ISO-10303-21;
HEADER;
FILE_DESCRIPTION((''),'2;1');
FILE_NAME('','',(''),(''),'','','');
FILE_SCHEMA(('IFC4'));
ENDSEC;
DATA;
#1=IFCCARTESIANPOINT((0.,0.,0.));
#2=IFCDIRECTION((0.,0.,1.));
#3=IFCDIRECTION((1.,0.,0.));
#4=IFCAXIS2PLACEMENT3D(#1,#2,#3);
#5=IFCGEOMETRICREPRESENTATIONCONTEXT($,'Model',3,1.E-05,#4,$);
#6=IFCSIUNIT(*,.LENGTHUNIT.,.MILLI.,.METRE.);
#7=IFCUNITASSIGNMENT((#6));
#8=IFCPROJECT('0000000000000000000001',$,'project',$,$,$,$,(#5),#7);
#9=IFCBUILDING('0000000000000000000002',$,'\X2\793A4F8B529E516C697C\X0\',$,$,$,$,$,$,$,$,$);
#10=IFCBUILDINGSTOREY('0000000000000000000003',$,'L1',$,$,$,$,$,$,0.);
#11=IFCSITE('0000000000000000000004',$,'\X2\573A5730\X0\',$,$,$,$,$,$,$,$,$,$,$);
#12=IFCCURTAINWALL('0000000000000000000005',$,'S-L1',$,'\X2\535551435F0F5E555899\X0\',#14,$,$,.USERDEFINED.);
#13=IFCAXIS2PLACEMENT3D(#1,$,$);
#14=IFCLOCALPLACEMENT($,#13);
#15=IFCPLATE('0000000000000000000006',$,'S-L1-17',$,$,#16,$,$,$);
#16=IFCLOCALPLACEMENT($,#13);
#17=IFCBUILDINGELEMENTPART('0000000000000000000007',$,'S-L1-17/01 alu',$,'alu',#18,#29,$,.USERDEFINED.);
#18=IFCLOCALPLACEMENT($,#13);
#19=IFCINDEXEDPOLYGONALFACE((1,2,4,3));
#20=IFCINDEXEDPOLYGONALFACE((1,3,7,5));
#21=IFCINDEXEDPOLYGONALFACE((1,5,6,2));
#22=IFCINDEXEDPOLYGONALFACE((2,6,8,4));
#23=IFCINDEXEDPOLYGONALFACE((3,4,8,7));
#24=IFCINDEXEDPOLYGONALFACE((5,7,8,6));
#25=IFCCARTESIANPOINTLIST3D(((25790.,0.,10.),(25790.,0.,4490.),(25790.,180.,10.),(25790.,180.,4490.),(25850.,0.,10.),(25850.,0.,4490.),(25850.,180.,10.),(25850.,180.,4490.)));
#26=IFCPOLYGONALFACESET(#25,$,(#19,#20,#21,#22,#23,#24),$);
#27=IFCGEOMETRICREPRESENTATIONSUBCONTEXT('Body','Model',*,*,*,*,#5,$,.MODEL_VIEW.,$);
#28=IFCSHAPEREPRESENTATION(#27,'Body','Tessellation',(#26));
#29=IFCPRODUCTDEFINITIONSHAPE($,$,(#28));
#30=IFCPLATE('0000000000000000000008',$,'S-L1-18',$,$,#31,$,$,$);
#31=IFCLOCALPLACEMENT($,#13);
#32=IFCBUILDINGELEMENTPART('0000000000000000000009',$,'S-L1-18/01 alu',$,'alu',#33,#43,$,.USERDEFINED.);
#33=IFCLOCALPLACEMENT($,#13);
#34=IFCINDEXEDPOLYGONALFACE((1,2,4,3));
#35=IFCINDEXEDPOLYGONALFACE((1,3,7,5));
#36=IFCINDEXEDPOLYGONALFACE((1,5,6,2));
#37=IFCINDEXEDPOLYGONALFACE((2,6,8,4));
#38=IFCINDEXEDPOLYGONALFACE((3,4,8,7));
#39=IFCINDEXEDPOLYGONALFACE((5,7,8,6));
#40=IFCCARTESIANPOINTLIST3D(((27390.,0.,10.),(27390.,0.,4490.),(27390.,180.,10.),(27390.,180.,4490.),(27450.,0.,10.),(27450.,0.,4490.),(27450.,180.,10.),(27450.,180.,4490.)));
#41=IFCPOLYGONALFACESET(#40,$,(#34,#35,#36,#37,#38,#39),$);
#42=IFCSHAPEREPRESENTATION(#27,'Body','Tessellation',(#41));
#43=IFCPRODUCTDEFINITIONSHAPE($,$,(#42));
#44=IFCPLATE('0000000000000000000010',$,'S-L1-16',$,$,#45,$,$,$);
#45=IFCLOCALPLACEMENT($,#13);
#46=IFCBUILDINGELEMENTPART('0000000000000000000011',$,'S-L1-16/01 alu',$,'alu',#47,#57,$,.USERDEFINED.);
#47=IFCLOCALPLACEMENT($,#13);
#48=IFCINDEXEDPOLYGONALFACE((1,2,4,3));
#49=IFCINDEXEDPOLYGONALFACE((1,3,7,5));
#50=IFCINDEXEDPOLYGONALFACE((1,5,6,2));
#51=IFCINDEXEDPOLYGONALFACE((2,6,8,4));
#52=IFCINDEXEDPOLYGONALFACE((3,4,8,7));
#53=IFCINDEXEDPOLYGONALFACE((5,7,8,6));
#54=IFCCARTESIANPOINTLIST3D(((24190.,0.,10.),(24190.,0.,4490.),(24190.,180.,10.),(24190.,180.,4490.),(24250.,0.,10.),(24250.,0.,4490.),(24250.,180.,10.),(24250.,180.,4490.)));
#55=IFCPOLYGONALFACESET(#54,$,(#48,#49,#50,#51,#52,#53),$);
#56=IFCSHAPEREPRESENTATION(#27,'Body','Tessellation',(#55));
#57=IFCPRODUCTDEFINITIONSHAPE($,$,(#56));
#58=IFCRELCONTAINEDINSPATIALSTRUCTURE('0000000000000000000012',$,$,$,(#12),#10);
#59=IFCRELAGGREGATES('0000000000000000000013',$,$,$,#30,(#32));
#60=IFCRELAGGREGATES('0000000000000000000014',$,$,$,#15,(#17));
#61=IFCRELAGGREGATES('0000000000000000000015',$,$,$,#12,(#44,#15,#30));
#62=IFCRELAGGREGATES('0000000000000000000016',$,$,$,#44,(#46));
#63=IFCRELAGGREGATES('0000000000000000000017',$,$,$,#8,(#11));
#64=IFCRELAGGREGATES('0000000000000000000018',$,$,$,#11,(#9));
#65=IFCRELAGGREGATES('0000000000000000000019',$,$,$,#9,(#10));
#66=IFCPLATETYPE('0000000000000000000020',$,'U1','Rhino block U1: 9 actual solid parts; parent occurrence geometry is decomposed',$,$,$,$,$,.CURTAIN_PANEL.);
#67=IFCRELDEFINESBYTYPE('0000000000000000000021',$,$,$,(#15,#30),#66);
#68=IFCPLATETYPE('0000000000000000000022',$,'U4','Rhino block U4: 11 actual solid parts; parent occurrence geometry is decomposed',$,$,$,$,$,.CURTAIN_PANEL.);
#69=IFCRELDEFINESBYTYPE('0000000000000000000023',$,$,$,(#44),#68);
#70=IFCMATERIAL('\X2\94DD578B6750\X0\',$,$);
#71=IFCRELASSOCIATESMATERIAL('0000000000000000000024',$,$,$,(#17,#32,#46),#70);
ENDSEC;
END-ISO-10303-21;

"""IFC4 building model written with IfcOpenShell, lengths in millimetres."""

from ifc_helpers import new_model, si_unit, frame, frame_2d, origin, origin_with_axes, place, context, subcontext, project, spatial, rectangle, extrude, source, transform, mapped, material, type_object, element, aggregate, save


model = new_model("IFC4")

# Units and contexts
model_context = context("Model", 3, precision=1e-05, world=origin_with_axes())
body_context = subcontext(model_context, "Body", "Model", "MODEL_VIEW")
ifc_project = project(units=[si_unit("LENGTHUNIT", "METRE", prefix="MILLI")], contexts=[model_context])

# Site, building, storey
site = spatial("IfcSite", under=ifc_project, Name="场地")
building = spatial("IfcBuilding", under=site, Name="示例办公楼")
storey = spatial("IfcBuildingStorey", under=building, Name="L1", Elevation=0.0)

# Curtain wall, plates, building element parts
curtain_wall = element("IfcCurtainWall", 1, inside=storey, Name="S-L1", ObjectType="单元式幕墙", PredefinedType="USERDEFINED")
plate_type_1 = type_object("IfcPlateType", Name="U1", Description="Rhino block U1: 9 actual solid parts; parent occurrence geometry is decomposed", PredefinedType="CURTAIN_PANEL")
plate_1_placement = place(None, frame((25790.0, 0.0, 10.0), z_axis=(0.0, 0.0, 1.0), x_axis=(1.0, 0.0, 0.0)))
plate_1 = element("IfcPlate", 2, at=plate_1_placement, type_object=plate_type_1, Name="S-L1-17")
ifc_material_1 = material(Name="铝型材")
shared_shape_1 = source(origin(), body_context, "Body", "SweptSolid", [
    extrude(rectangle(XDim=60.0, YDim=180.0, at=frame_2d((30.0, 90.0))), origin(), (0.0, 0.0, 1.0), 4480.0),
])
building_element_part_1_placement = place(plate_1_placement, origin())
building_element_part_1 = element("IfcBuildingElementPart", 3, at=building_element_part_1_placement, material=ifc_material_1, Name="S-L1-17/01 alu", ObjectType="alu", PredefinedType="USERDEFINED", context=body_context, shape_type="MappedRepresentation", body=[
    mapped(shared_shape_1, transform((0.0, 0.0, 0.0))),
])
plate_2_placement = place(None, frame((27390.0, 0.0, 10.0), z_axis=(0.0, 0.0, 1.0), x_axis=(1.0, 0.0, 0.0)))
plate_2 = element("IfcPlate", 4, at=plate_2_placement, type_object=plate_type_1, Name="S-L1-18")
building_element_part_2_placement = place(plate_2_placement, origin())
building_element_part_2 = element("IfcBuildingElementPart", 5, at=building_element_part_2_placement, material=ifc_material_1, Name="S-L1-18/01 alu", ObjectType="alu", PredefinedType="USERDEFINED", context=body_context, shape_type="MappedRepresentation", body=[
    mapped(shared_shape_1, transform((0.0, 0.0, 0.0))),
])
aggregate(plate_2, [building_element_part_2])
aggregate(plate_1, [building_element_part_1])
plate_type_2 = type_object("IfcPlateType", Name="U4", Description="Rhino block U4: 11 actual solid parts; parent occurrence geometry is decomposed", PredefinedType="CURTAIN_PANEL")
plate_3_placement = place(None, frame((24190.0, 0.0, 10.0), z_axis=(0.0, 0.0, 1.0), x_axis=(1.0, 0.0, 0.0)))
plate_3 = element("IfcPlate", 6, at=plate_3_placement, type_object=plate_type_2, Name="S-L1-16")
aggregate(curtain_wall, [plate_3, plate_1, plate_2])
shared_shape_2 = source(origin(), body_context, "Body", "SweptSolid", [
    extrude(rectangle(XDim=60.0, YDim=180.0, at=frame_2d((30.0, 90.0))), origin(), (0.0, 0.0, 1.0), 4480.0),
])
building_element_part_3_placement = place(plate_3_placement, origin())
building_element_part_3 = element("IfcBuildingElementPart", 7, at=building_element_part_3_placement, material=ifc_material_1, Name="S-L1-16/01 alu", ObjectType="alu", PredefinedType="USERDEFINED", context=body_context, shape_type="MappedRepresentation", body=[
    mapped(shared_shape_2, transform((0.0, 0.0, 0.0))),
])
aggregate(plate_3, [building_element_part_3])

save(model, "model.ifc")
